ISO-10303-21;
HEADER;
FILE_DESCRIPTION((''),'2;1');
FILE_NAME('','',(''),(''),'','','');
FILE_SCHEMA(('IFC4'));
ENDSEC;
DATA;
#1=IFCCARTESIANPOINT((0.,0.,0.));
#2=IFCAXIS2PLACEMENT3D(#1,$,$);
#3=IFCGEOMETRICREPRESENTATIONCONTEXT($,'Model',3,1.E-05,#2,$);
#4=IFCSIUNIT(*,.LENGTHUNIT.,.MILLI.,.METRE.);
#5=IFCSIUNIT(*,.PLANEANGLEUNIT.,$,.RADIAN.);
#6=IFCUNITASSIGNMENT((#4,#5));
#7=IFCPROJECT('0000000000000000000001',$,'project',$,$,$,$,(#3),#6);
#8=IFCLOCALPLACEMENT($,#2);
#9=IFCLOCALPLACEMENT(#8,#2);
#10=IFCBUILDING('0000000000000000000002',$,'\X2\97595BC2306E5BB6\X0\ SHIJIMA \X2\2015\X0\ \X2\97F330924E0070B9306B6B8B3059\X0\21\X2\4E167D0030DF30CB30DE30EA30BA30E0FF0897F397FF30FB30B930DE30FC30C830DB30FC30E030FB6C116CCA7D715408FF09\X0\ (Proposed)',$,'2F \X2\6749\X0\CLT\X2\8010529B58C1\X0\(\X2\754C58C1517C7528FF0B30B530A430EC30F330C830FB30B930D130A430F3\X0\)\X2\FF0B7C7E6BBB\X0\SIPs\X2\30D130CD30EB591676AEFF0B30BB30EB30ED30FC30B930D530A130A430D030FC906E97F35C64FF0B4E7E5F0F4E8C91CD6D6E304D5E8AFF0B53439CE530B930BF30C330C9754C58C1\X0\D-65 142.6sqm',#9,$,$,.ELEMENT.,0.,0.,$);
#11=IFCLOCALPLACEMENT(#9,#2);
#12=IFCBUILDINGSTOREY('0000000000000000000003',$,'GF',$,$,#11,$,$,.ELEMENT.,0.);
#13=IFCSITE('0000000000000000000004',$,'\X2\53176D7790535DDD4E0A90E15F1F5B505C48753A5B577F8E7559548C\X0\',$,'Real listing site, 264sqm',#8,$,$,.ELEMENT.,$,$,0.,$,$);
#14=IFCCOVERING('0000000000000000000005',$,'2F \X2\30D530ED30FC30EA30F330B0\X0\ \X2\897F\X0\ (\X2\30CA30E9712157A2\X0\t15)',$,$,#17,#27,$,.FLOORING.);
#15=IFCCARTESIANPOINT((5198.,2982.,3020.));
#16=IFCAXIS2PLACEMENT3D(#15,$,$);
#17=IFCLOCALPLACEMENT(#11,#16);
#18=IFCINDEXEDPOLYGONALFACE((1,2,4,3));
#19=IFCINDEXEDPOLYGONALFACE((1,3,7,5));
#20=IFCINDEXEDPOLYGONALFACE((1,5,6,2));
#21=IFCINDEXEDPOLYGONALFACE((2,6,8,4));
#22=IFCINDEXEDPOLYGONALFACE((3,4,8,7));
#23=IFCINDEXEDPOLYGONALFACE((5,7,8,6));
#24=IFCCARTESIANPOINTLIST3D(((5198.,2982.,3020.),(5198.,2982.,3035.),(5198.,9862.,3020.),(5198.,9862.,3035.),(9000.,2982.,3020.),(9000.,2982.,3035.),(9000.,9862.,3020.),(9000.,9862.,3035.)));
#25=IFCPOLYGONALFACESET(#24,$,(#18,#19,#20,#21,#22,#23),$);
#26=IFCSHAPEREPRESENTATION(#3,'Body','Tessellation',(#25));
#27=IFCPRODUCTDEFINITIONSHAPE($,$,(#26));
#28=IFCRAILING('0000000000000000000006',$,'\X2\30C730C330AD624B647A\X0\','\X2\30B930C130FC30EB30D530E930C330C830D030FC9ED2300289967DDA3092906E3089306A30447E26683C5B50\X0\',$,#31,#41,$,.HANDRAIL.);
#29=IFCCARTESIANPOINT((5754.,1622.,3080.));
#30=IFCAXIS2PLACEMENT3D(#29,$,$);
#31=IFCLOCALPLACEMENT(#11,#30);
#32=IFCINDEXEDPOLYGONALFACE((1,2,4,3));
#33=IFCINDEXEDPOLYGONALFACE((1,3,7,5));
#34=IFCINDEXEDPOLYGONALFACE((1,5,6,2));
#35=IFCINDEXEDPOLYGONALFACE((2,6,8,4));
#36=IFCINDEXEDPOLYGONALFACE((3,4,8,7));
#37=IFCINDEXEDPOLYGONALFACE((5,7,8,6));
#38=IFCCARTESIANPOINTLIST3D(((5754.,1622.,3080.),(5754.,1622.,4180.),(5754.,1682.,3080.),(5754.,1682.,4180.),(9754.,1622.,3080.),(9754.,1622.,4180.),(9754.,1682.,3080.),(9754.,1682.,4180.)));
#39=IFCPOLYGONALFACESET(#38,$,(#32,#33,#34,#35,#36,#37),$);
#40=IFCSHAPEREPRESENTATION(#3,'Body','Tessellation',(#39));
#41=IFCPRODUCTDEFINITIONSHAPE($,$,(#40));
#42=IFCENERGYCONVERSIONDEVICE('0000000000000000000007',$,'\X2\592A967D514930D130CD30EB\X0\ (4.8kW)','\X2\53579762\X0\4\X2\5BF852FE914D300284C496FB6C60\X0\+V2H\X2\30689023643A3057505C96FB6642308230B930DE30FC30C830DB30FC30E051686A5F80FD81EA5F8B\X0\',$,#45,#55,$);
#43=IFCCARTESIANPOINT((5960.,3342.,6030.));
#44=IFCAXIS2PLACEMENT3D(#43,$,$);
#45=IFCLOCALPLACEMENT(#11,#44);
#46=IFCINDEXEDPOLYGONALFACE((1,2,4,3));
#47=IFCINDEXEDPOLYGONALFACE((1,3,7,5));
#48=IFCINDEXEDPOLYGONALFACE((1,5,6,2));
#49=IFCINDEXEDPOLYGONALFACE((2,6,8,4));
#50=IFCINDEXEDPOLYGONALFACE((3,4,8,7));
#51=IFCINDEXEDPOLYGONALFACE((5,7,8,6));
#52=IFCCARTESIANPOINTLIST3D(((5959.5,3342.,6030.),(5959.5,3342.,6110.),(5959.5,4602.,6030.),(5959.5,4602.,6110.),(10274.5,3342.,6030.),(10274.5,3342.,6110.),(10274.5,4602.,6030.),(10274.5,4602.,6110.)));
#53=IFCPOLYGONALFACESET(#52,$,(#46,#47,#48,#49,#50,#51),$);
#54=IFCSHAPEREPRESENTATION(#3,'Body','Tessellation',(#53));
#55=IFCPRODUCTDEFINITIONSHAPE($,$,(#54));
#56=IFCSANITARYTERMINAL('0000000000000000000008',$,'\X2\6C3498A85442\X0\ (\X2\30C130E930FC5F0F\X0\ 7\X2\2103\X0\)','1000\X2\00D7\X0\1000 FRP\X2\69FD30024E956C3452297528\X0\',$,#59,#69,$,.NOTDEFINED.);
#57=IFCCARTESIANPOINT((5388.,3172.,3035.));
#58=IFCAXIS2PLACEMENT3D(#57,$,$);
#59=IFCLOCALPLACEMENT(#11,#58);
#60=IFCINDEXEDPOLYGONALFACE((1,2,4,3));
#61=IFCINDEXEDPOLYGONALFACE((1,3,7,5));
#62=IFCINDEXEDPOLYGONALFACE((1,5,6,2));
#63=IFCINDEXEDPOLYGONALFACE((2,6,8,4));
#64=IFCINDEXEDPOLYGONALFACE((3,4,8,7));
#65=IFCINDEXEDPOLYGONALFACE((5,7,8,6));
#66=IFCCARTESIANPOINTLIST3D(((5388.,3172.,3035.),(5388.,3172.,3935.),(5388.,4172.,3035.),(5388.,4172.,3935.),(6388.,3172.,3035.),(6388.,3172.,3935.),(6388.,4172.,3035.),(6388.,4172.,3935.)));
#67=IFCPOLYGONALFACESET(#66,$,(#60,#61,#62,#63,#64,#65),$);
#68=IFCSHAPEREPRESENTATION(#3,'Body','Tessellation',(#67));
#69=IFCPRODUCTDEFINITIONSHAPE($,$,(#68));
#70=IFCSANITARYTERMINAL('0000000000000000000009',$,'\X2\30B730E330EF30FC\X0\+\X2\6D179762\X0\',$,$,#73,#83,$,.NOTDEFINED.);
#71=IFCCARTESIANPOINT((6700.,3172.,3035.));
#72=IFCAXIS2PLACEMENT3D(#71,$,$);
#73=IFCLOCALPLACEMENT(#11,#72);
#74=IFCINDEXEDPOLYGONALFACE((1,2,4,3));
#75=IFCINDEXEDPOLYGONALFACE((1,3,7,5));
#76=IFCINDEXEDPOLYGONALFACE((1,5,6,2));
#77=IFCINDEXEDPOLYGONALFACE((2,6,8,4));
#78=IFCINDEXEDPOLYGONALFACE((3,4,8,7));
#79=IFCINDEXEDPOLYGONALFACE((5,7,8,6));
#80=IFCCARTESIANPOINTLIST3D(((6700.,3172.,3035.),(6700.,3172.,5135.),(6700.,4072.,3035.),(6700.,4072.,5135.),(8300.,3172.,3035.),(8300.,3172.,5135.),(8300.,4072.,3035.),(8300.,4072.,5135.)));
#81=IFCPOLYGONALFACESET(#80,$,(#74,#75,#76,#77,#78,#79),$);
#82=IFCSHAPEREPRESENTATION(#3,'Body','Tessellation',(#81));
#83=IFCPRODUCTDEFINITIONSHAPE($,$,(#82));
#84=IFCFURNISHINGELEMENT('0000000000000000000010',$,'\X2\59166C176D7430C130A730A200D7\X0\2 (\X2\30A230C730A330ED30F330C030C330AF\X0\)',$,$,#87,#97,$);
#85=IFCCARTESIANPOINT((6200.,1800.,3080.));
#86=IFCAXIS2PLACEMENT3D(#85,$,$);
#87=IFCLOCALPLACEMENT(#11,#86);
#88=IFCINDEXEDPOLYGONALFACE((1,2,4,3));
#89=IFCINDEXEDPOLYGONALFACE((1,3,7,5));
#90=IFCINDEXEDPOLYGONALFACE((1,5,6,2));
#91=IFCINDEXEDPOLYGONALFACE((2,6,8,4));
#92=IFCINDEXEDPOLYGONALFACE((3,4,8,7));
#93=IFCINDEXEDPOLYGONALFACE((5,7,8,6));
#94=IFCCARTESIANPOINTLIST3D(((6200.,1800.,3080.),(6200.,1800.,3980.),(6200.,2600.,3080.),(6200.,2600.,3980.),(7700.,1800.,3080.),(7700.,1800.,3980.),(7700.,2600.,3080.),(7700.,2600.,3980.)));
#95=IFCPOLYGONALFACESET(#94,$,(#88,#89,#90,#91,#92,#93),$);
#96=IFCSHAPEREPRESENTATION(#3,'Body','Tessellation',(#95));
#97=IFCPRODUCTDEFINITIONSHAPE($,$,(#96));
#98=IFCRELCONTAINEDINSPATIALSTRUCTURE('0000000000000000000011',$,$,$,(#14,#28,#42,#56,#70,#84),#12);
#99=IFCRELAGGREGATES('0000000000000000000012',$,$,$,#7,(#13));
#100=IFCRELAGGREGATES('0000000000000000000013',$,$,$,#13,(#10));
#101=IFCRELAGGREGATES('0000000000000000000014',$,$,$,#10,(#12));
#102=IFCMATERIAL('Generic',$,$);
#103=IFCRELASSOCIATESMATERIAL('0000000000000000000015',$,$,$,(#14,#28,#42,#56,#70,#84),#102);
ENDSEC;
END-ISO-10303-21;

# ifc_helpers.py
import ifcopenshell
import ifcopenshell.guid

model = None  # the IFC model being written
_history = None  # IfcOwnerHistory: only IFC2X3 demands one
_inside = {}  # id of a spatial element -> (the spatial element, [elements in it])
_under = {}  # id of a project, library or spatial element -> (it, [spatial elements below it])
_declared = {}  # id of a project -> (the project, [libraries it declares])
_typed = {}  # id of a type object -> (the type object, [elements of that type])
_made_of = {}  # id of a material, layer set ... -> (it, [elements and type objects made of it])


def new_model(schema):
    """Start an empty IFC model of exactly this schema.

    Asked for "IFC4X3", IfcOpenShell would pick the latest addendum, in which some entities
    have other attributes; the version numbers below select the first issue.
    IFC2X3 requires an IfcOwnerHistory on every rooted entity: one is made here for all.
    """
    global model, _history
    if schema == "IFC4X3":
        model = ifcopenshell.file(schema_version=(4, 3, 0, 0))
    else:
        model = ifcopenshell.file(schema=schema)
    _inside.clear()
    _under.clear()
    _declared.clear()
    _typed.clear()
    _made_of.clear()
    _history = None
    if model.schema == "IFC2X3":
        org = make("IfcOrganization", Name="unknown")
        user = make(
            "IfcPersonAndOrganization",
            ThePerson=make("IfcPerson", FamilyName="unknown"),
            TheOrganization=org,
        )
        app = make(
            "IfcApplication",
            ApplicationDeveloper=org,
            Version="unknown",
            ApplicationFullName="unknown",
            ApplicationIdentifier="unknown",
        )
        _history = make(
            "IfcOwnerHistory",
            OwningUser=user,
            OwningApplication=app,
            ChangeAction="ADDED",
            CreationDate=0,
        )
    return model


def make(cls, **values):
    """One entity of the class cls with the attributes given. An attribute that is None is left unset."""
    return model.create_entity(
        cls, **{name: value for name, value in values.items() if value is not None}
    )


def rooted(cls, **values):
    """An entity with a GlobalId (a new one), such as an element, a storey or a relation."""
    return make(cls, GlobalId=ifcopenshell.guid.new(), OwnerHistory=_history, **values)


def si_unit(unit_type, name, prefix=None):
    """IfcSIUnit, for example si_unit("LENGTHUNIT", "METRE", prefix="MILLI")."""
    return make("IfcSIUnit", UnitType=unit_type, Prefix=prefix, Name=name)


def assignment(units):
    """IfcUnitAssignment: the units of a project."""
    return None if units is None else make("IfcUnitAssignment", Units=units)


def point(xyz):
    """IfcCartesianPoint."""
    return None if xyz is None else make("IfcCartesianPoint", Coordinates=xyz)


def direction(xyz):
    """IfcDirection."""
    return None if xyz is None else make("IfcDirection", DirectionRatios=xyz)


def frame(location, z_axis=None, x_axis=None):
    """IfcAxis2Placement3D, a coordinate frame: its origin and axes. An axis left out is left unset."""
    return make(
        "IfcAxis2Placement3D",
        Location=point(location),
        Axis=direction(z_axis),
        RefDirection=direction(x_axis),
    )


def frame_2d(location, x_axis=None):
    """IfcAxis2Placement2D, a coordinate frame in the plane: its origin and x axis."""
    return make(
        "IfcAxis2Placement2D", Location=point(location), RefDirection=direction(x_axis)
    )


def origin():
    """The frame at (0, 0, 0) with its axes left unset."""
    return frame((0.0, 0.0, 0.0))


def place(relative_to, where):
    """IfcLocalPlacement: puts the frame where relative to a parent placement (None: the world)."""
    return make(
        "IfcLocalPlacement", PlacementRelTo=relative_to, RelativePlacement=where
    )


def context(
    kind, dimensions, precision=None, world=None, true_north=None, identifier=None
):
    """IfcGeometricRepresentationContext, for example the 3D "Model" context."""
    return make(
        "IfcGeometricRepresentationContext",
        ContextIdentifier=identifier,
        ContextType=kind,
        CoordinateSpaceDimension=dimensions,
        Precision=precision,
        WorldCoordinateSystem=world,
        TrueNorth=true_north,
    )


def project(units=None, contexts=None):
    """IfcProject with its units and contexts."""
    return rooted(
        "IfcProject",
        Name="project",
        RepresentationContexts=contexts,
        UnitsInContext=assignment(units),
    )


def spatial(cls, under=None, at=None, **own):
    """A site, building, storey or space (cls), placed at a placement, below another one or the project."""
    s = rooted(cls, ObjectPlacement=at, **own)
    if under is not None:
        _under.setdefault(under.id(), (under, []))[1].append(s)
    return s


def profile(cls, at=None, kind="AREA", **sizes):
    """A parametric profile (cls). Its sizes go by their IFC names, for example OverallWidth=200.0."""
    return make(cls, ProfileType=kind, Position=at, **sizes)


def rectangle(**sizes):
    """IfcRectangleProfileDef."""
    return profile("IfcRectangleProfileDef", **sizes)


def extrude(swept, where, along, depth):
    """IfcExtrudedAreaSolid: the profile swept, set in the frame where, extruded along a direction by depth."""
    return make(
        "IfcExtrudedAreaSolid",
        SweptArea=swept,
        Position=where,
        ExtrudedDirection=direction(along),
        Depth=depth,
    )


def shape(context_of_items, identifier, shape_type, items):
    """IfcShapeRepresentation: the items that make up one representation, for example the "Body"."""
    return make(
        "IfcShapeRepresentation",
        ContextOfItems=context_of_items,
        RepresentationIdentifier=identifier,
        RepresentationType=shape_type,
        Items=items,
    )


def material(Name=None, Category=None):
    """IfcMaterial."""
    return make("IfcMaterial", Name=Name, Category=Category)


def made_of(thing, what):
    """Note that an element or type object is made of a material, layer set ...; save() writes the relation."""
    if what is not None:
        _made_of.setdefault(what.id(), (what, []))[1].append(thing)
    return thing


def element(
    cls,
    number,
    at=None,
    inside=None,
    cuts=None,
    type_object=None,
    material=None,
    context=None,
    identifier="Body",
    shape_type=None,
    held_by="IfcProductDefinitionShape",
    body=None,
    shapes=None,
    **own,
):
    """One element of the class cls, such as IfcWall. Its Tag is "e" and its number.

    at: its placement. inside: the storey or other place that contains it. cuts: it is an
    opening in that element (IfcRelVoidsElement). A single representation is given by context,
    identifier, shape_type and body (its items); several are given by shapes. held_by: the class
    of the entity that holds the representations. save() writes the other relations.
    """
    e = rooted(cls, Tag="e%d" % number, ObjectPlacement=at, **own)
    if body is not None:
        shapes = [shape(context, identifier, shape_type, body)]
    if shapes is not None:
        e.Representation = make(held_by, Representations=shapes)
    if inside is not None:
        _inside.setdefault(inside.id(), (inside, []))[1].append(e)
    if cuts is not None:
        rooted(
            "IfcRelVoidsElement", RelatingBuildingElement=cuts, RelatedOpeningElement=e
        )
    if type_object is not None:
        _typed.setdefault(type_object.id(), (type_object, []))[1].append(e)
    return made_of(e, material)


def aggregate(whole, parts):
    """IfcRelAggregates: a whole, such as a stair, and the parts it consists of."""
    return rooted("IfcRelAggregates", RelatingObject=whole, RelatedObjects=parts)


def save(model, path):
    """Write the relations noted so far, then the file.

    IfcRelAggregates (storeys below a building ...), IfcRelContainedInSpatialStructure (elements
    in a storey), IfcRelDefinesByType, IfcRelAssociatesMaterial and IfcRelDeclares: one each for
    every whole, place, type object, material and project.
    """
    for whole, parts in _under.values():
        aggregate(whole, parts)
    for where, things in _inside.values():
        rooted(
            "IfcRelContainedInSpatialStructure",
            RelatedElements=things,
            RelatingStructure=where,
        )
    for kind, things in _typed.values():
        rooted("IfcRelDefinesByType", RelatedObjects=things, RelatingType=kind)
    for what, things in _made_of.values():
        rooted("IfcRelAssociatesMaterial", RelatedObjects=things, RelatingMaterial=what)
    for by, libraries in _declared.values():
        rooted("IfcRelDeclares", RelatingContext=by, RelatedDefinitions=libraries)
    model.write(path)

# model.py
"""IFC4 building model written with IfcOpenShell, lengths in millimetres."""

from ifc_helpers import new_model, si_unit, frame, frame_2d, origin, place, context, project, spatial, rectangle, extrude, material, element, save


model = new_model("IFC4")

# Units and contexts
model_context = context("Model", 3, precision=1e-05, world=origin())
ifc_project = project(units=[si_unit("LENGTHUNIT", "METRE", prefix="MILLI"), si_unit("PLANEANGLEUNIT", "RADIAN")], contexts=[model_context])

# Site, building, storey
site_placement = place(None, origin())
site = spatial("IfcSite", under=ifc_project, at=site_placement, Name="北海道川上郡弟子屈町字美留和", ObjectType="Real listing site, 264sqm", CompositionType="ELEMENT", RefElevation=0.0)
building_placement = place(site_placement, origin())
building = spatial("IfcBuilding", under=site, at=building_placement, Name="静寂の家 SHIJIMA ― 音を一点に残す21世紀ミニマリズム（音響・スマートホーム・民泊統合） (Proposed)", ObjectType="2F 杉CLT耐力壁(界壁兼用＋サイレント・スパイン)＋籾殻SIPsパネル外皮＋セルロースファイバー遮音層＋乾式二重浮き床＋千鳥スタッド界壁D-65 142.6sqm", CompositionType="ELEMENT", ElevationOfRefHeight=0.0, ElevationOfTerrain=0.0)
storey_placement = place(building_placement, origin())
storey = spatial("IfcBuildingStorey", under=building, at=storey_placement, Name="GF", CompositionType="ELEMENT", Elevation=0.0)

# Shared definitions
ifc_material = material(Name="Generic")

# Covering
covering_placement = place(storey_placement, frame((5198.0, 2982.0, 3020.0)))
element("IfcCovering", 1, at=covering_placement, inside=storey, material=ifc_material, Name="2F フローリング 西 (ナラ無垢t15)", PredefinedType="FLOORING", context=model_context, shape_type="SweptSolid", body=[
    extrude(rectangle(XDim=3802.0, YDim=6880.0, at=frame_2d((1901.0, 3440.0))), frame((5198.0, 2982.0, 3020.0)), (0.0, 0.0, 1.0), 15.0),
])

# Railing
railing_placement = place(storey_placement, frame((5754.0, 1622.0, 3080.0)))
element("IfcRailing", 2, at=railing_placement, inside=storey, material=ifc_material, Name="デッキ手摺", Description="スチールフラットバー黒。視線を遮らない縦格子", PredefinedType="HANDRAIL", context=model_context, shape_type="SweptSolid", body=[
    extrude(rectangle(XDim=4000.0, YDim=60.0, at=frame_2d((2000.0, 30.0))), frame((5754.0, 1622.0, 3080.0)), (0.0, 0.0, 1.0), 1100.0),
])

# Energy conversion device
energy_conversion_device_placement = place(storey_placement, frame((5960.0, 3342.0, 6030.0)))
element("IfcEnergyConversionDevice", 3, at=energy_conversion_device_placement, inside=storey, material=ifc_material, Name="太陽光パネル (4.8kW)", Description="南面4寸勾配。蓄電池+V2Hと連携し停電時もスマートホーム全機能自律", context=model_context, shape_type="SweptSolid", body=[
    extrude(rectangle(XDim=4315.0, YDim=1260.0, at=frame_2d((2157.0, 630.0))), frame((5960.0, 3342.0, 6030.0)), (0.0, 0.0, 1.0), 80.0),
])

# Sanitary terminals
sanitary_terminal_1_placement = place(storey_placement, frame((5388.0, 3172.0, 3035.0)))
element("IfcSanitaryTerminal", 4, at=sanitary_terminal_1_placement, inside=storey, material=ifc_material, Name="水風呂 (チラー式 7℃)", Description="1000×1000 FRP槽。井水利用", PredefinedType="NOTDEFINED", context=model_context, shape_type="SweptSolid", body=[
    extrude(rectangle(XDim=1000.0, YDim=1000.0, at=frame_2d((500.0, 500.0))), frame((5388.0, 3172.0, 3035.0)), (0.0, 0.0, 1.0), 900.0),
])
sanitary_terminal_2_placement = place(storey_placement, frame((6700.0, 3172.0, 3035.0)))
element("IfcSanitaryTerminal", 5, at=sanitary_terminal_2_placement, inside=storey, material=ifc_material, Name="シャワー+洗面", PredefinedType="NOTDEFINED", context=model_context, shape_type="SweptSolid", body=[
    extrude(rectangle(XDim=1600.0, YDim=900.0, at=frame_2d((800.0, 450.0))), frame((6700.0, 3172.0, 3035.0)), (0.0, 0.0, 1.0), 2100.0),
])

# Furnishing element
furnishing_placement = place(storey_placement, frame((6200.0, 1800.0, 3080.0)))
element("IfcFurnishingElement", 6, at=furnishing_placement, inside=storey, material=ifc_material, Name="外気浴チェア×2 (アディロンダック)", context=model_context, shape_type="SweptSolid", body=[
    extrude(rectangle(XDim=1500.0, YDim=800.0, at=frame_2d((750.0, 400.0))), frame((6200.0, 1800.0, 3080.0)), (0.0, 0.0, 1.0), 900.0),
])

save(model, "model.ifc")
